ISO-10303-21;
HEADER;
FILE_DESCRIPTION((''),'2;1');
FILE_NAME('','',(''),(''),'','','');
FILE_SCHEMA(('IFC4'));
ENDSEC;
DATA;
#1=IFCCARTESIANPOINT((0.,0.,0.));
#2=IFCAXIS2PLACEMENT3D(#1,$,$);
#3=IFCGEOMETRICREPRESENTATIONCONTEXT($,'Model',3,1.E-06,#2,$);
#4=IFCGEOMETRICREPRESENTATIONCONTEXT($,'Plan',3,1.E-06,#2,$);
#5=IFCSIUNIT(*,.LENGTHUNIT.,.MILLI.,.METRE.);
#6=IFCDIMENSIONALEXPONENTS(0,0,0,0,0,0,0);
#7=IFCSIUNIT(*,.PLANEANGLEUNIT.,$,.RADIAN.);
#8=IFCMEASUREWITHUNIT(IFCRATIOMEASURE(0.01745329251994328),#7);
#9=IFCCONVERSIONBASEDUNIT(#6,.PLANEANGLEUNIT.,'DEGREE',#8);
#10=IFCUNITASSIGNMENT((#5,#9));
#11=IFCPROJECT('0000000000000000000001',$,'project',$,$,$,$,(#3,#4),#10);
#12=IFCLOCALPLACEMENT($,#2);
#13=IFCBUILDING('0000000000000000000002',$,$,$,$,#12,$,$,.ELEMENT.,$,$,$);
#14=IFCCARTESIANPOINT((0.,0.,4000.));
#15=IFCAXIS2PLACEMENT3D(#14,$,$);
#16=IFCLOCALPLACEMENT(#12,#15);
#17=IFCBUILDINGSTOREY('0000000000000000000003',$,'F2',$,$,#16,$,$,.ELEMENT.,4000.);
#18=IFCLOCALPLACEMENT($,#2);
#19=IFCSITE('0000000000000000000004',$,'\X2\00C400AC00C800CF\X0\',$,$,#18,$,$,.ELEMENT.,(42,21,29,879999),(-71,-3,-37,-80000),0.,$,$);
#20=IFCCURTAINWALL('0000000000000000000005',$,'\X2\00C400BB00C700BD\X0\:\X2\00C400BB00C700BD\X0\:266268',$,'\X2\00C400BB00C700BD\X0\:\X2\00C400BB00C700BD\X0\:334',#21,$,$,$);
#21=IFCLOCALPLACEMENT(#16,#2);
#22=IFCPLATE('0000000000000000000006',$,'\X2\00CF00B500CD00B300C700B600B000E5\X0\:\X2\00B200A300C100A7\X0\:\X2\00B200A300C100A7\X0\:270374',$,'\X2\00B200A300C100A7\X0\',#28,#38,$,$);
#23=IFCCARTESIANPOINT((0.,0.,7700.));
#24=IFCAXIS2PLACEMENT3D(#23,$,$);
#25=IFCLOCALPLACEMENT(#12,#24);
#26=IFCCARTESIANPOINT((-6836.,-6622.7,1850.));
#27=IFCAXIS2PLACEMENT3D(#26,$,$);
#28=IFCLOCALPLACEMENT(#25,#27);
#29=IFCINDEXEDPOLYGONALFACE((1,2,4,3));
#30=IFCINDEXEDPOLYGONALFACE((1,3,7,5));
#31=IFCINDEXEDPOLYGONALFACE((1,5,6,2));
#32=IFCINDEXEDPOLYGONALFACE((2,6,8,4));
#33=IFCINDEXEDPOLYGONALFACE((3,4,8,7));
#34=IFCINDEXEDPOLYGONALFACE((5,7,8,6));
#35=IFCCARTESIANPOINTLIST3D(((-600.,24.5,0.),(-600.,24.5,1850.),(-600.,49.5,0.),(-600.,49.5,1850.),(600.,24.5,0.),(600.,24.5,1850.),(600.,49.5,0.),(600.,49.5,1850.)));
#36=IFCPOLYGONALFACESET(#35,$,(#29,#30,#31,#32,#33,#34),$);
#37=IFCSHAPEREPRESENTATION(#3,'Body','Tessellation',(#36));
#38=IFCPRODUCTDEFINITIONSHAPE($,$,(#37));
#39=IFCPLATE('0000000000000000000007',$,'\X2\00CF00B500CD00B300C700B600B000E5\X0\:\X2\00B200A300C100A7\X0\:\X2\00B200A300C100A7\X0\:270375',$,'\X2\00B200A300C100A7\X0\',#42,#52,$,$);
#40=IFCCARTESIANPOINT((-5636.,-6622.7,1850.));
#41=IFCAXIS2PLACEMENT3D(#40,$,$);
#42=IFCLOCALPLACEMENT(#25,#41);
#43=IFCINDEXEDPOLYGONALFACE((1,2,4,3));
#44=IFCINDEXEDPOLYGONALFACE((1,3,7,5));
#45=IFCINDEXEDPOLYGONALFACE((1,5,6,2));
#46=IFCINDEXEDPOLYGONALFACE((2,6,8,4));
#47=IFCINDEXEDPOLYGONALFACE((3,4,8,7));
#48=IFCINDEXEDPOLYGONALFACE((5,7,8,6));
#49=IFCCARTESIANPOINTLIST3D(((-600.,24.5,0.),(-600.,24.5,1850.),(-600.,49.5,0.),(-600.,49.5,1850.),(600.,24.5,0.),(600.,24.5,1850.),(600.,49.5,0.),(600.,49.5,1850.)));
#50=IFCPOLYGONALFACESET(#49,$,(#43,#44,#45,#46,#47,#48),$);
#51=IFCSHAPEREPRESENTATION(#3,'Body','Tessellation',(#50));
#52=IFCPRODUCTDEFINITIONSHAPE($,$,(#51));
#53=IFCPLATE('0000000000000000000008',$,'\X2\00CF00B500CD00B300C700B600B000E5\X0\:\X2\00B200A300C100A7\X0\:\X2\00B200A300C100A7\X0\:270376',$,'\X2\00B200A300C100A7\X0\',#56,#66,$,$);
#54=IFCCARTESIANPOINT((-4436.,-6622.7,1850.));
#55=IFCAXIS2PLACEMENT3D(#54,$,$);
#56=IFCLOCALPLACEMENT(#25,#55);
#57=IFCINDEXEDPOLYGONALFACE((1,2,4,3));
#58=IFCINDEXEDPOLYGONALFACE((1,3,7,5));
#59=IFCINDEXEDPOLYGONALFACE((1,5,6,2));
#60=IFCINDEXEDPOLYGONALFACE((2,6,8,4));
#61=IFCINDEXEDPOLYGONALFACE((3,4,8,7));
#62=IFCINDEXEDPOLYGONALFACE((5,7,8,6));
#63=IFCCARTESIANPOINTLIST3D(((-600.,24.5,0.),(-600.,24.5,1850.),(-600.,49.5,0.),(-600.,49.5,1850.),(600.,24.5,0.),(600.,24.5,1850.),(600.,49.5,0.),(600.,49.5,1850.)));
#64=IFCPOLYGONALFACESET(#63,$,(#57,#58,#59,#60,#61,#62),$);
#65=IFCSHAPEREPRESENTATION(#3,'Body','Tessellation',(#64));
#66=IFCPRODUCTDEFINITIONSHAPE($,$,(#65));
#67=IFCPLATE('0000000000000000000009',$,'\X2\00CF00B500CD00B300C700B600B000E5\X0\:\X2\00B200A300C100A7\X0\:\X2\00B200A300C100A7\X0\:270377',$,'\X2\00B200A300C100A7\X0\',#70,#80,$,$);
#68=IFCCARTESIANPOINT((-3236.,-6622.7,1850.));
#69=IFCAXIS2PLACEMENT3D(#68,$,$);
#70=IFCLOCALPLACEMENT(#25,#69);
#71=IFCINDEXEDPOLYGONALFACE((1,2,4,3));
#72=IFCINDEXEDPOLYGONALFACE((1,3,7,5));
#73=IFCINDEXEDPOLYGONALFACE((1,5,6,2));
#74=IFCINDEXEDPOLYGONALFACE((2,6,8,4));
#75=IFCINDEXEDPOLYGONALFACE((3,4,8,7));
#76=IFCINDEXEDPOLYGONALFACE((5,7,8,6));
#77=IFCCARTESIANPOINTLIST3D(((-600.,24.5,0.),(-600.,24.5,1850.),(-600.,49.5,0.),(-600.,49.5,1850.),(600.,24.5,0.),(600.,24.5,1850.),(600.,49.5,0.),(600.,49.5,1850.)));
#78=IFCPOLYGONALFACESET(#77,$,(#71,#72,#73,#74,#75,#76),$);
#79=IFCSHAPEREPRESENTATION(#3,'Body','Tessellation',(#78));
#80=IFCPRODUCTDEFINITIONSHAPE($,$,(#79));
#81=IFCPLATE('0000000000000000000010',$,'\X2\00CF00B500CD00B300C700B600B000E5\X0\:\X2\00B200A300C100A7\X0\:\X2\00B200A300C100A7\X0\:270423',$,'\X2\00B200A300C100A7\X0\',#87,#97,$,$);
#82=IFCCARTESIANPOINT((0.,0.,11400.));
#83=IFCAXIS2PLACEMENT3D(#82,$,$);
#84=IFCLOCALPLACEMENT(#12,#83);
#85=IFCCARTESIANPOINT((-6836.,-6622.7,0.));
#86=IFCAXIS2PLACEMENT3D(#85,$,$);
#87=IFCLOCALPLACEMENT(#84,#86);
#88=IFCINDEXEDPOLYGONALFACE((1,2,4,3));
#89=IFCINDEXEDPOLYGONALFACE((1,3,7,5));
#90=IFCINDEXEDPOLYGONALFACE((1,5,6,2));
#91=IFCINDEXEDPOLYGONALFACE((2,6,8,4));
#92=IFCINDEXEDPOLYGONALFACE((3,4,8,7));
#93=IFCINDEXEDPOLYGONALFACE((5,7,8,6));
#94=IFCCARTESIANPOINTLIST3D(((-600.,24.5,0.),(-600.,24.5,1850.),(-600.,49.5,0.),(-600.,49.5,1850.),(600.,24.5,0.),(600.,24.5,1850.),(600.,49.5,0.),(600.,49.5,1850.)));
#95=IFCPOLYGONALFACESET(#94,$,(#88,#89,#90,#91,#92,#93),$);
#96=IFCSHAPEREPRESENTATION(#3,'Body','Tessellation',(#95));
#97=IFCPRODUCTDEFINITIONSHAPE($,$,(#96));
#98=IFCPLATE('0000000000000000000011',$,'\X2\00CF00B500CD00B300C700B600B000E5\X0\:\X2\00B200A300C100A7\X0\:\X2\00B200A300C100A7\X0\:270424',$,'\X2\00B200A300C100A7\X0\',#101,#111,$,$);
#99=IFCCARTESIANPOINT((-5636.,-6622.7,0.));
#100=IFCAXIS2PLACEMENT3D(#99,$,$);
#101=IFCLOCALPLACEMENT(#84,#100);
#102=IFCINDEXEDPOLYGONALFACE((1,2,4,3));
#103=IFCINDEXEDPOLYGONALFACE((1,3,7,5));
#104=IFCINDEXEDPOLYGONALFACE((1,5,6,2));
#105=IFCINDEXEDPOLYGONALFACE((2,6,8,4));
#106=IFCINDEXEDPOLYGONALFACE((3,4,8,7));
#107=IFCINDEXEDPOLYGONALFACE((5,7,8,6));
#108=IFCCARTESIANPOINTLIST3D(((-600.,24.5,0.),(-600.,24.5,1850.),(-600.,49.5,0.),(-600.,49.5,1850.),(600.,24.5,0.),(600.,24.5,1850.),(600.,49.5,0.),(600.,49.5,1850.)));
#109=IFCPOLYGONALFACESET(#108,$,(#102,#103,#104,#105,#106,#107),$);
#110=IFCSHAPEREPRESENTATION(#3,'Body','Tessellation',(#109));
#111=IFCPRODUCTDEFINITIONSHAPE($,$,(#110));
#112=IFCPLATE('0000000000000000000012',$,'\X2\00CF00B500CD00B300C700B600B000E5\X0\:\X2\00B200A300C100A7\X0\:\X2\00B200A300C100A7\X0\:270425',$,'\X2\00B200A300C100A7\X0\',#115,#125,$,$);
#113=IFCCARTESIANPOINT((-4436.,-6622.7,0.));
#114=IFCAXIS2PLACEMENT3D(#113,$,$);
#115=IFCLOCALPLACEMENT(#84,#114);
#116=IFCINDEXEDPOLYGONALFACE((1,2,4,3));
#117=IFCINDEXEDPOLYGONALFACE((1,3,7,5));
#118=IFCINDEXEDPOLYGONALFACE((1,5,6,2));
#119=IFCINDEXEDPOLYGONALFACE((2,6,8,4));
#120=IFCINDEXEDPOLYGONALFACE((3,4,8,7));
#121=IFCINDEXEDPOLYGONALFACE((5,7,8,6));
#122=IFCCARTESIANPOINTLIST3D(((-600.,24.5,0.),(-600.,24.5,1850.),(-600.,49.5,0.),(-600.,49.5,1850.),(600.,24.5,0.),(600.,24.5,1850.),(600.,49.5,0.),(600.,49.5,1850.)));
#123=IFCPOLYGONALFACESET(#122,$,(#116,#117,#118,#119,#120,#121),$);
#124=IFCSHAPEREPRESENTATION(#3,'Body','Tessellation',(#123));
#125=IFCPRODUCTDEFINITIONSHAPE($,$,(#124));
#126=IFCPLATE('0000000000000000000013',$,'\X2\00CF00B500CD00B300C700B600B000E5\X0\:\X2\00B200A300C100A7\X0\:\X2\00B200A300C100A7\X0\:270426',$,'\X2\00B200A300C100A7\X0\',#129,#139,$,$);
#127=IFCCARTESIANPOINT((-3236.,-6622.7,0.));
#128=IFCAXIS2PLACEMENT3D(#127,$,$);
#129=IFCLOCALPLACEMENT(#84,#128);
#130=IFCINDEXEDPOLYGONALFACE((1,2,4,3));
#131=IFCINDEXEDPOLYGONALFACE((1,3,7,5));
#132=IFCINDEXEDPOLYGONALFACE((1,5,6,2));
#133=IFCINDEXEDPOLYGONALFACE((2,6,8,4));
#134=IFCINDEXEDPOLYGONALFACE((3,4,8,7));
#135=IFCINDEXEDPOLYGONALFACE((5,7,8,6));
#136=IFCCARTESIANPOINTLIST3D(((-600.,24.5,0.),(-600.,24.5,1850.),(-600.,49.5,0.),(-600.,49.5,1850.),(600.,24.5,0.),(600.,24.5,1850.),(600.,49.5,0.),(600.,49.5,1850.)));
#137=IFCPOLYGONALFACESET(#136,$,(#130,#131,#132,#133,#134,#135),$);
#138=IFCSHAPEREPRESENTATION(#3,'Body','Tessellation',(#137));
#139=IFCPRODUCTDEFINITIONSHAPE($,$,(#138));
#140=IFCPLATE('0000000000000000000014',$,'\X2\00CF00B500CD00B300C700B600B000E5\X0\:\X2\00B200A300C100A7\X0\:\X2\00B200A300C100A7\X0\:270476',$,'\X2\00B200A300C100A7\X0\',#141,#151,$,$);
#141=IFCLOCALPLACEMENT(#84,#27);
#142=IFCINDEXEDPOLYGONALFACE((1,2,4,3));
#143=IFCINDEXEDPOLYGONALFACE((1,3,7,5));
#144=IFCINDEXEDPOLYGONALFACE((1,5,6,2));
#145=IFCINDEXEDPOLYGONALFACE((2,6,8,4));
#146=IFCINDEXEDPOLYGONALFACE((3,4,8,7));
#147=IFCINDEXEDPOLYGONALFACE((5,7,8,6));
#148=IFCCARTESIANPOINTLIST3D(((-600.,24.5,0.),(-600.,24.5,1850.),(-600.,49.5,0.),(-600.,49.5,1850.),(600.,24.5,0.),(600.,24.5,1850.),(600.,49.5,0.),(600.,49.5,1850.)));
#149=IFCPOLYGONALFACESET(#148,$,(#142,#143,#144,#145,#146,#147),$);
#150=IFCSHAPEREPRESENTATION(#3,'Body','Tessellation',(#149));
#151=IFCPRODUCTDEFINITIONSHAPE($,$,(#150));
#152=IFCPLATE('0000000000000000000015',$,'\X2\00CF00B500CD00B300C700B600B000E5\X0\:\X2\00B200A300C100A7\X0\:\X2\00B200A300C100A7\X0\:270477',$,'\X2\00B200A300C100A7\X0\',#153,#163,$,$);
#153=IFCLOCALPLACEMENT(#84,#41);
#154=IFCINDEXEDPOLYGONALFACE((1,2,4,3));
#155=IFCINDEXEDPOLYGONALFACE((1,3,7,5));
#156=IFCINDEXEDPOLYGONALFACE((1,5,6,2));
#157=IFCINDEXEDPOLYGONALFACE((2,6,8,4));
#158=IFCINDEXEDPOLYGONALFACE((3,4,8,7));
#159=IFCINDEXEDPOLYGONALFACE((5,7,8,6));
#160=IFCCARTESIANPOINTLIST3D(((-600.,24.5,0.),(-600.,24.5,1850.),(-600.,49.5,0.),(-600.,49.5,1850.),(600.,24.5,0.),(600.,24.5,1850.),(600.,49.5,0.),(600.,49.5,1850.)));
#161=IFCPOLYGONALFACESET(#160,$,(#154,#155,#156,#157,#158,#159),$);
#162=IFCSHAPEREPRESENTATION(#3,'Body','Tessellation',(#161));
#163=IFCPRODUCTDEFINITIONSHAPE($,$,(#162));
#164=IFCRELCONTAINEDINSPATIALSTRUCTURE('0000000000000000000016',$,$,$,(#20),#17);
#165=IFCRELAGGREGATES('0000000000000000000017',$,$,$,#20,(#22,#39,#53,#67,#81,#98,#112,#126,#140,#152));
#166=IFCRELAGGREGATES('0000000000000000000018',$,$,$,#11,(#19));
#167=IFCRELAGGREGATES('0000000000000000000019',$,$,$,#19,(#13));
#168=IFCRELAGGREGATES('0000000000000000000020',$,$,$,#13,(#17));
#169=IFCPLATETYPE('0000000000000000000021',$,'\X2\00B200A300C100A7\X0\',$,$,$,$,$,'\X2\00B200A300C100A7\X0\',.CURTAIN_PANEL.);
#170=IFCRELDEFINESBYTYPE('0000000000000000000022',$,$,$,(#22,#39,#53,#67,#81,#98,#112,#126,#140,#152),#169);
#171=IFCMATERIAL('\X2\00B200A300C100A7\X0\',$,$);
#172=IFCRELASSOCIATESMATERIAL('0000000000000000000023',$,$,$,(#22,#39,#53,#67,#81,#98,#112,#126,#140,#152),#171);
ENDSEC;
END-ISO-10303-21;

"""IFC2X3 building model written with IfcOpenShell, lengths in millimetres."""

from ifc_helpers import new_model, entity, si_unit, converted_unit, frame, origin, origin_2d_with_axis, place, context, project, spatial, rectangle, extrude, source, transform, mapped, material, type_object, type_shapes, element, aggregate, save


model = new_model("IFC2X3")

# Units and contexts
model_context = context("Model", 3, precision=1e-06, world=origin())
plan_context = context("Plan", 3, precision=1e-06, world=origin())
ifc_project = project(units=[si_unit("LENGTHUNIT", "METRE", prefix="MILLI"), converted_unit("PLANEANGLEUNIT", "DEGREE", entity("IfcRatioMeasure", 0.01745329251994328), si_unit("PLANEANGLEUNIT", "RADIAN"), dimensions=[0, 0, 0, 0, 0, 0, 0])], contexts=[model_context, plan_context])

# Site, building, storey
site_placement = place(None, origin())
site = spatial("IfcSite", under=ifc_project, at=site_placement, Name="Ä¬ÈÏ", CompositionType="ELEMENT", RefLatitude=(42, 21, 29, 879999), RefLongitude=(-71, -3, -37, -80000), RefElevation=0.0)
building_placement = place(None, origin())
building = spatial("IfcBuilding", under=site, at=building_placement, CompositionType="ELEMENT")
storey_placement = place(building_placement, frame((0.0, 0.0, 4000.0)))
storey = spatial("IfcBuildingStorey", under=building, at=storey_placement, Name="F2", CompositionType="ELEMENT", Elevation=4000.0)

# Curtain wall, plates
curtain_wall_placement = place(storey_placement, origin())
curtain_wall = element("IfcCurtainWall", 1, at=curtain_wall_placement, inside=storey, Name="Ä»Ç½:Ä»Ç½:266268", ObjectType="Ä»Ç½:Ä»Ç½:334")
placement_1 = place(building_placement, frame((0.0, 0.0, 11400.0)))
placement_2 = place(building_placement, frame((0.0, 0.0, 7700.0)))
ifc_material_1 = material(Name="²£Á§")
plate_type = type_object("IfcPlateType", Name="²£Á§", ElementType="²£Á§", PredefinedType="CURTAIN_PANEL")
shared_shape_1 = source(origin(), model_context, "Body", "SweptSolid", [
    extrude(rectangle(XDim=25.0, YDim=1200.0, at=origin_2d_with_axis()), frame((0.0, 37.0, 0.0), z_axis=(0.0, 0.0, 1.0), x_axis=(0.0, 1.0, 0.0)), (0.0, 0.0, 1.0), 1850.0),
])
type_shapes(plate_type, [shared_shape_1])
plate_1_placement = place(placement_2, frame((-6836.0, -6622.7, 1850.0)))
plate_1 = element("IfcPlate", 2, at=plate_1_placement, type_object=plate_type, material=ifc_material_1, Name="ÏµÍ³Ç¶°å:²£Á§:²£Á§:270374", ObjectType="²£Á§", context=model_context, shape_type="MappedRepresentation", body=[
    mapped(shared_shape_1, transform((0.0, 0.0, 0.0), scale=1.0)),
])
plate_2_placement = place(placement_2, frame((-5636.0, -6622.7, 1850.0)))
plate_2 = element("IfcPlate", 3, at=plate_2_placement, type_object=plate_type, material=ifc_material_1, Name="ÏµÍ³Ç¶°å:²£Á§:²£Á§:270375", ObjectType="²£Á§", context=model_context, shape_type="MappedRepresentation", body=[
    mapped(shared_shape_1, transform((0.0, 0.0, 0.0), scale=1.0)),
])
plate_3_placement = place(placement_2, frame((-4436.0, -6622.7, 1850.0)))
plate_3 = element("IfcPlate", 4, at=plate_3_placement, type_object=plate_type, material=ifc_material_1, Name="ÏµÍ³Ç¶°å:²£Á§:²£Á§:270376", ObjectType="²£Á§", context=model_context, shape_type="MappedRepresentation", body=[
    mapped(shared_shape_1, transform((0.0, 0.0, 0.0), scale=1.0)),
])
plate_4_placement = place(placement_2, frame((-3236.0, -6622.7, 1850.0)))
plate_4 = element("IfcPlate", 5, at=plate_4_placement, type_object=plate_type, material=ifc_material_1, Name="ÏµÍ³Ç¶°å:²£Á§:²£Á§:270377", ObjectType="²£Á§", context=model_context, shape_type="MappedRepresentation", body=[
    mapped(shared_shape_1, transform((0.0, 0.0, 0.0), scale=1.0)),
])
plate_5_placement = place(placement_1, frame((-6836.0, -6622.7, 0.0)))
plate_5 = element("IfcPlate", 6, at=plate_5_placement, type_object=plate_type, material=ifc_material_1, Name="ÏµÍ³Ç¶°å:²£Á§:²£Á§:270423", ObjectType="²£Á§", context=model_context, shape_type="MappedRepresentation", body=[
    mapped(shared_shape_1, transform((0.0, 0.0, 0.0), scale=1.0)),
])
plate_6_placement = place(placement_1, frame((-5636.0, -6622.7, 0.0)))
plate_6 = element("IfcPlate", 7, at=plate_6_placement, type_object=plate_type, material=ifc_material_1, Name="ÏµÍ³Ç¶°å:²£Á§:²£Á§:270424", ObjectType="²£Á§", context=model_context, shape_type="MappedRepresentation", body=[
    mapped(shared_shape_1, transform((0.0, 0.0, 0.0), scale=1.0)),
])
plate_7_placement = place(placement_1, frame((-4436.0, -6622.7, 0.0)))
plate_7 = element("IfcPlate", 8, at=plate_7_placement, type_object=plate_type, material=ifc_material_1, Name="ÏµÍ³Ç¶°å:²£Á§:²£Á§:270425", ObjectType="²£Á§", context=model_context, shape_type="MappedRepresentation", body=[
    mapped(shared_shape_1, transform((0.0, 0.0, 0.0), scale=1.0)),
])
plate_8_placement = place(placement_1, frame((-3236.0, -6622.7, 0.0)))
plate_8 = element("IfcPlate", 9, at=plate_8_placement, type_object=plate_type, material=ifc_material_1, Name="ÏµÍ³Ç¶°å:²£Á§:²£Á§:270426", ObjectType="²£Á§", context=model_context, shape_type="MappedRepresentation", body=[
    mapped(shared_shape_1, transform((0.0, 0.0, 0.0), scale=1.0)),
])
plate_9_placement = place(placement_1, frame((-6836.0, -6622.7, 1850.0)))
plate_9 = element("IfcPlate", 10, at=plate_9_placement, type_object=plate_type, material=ifc_material_1, Name="ÏµÍ³Ç¶°å:²£Á§:²£Á§:270476", ObjectType="²£Á§", context=model_context, shape_type="MappedRepresentation", body=[
    mapped(shared_shape_1, transform((0.0, 0.0, 0.0), scale=1.0)),
])
plate_10_placement = place(placement_1, frame((-5636.0, -6622.7, 1850.0)))
plate_10 = element("IfcPlate", 11, at=plate_10_placement, type_object=plate_type, material=ifc_material_1, Name="ÏµÍ³Ç¶°å:²£Á§:²£Á§:270477", ObjectType="²£Á§", context=model_context, shape_type="MappedRepresentation", body=[
    mapped(shared_shape_1, transform((0.0, 0.0, 0.0), scale=1.0)),
])
aggregate(curtain_wall, [plate_1, plate_2, plate_3, plate_4, plate_5, plate_6, plate_7, plate_8, plate_9, plate_10])

save(model, "model.ifc")
